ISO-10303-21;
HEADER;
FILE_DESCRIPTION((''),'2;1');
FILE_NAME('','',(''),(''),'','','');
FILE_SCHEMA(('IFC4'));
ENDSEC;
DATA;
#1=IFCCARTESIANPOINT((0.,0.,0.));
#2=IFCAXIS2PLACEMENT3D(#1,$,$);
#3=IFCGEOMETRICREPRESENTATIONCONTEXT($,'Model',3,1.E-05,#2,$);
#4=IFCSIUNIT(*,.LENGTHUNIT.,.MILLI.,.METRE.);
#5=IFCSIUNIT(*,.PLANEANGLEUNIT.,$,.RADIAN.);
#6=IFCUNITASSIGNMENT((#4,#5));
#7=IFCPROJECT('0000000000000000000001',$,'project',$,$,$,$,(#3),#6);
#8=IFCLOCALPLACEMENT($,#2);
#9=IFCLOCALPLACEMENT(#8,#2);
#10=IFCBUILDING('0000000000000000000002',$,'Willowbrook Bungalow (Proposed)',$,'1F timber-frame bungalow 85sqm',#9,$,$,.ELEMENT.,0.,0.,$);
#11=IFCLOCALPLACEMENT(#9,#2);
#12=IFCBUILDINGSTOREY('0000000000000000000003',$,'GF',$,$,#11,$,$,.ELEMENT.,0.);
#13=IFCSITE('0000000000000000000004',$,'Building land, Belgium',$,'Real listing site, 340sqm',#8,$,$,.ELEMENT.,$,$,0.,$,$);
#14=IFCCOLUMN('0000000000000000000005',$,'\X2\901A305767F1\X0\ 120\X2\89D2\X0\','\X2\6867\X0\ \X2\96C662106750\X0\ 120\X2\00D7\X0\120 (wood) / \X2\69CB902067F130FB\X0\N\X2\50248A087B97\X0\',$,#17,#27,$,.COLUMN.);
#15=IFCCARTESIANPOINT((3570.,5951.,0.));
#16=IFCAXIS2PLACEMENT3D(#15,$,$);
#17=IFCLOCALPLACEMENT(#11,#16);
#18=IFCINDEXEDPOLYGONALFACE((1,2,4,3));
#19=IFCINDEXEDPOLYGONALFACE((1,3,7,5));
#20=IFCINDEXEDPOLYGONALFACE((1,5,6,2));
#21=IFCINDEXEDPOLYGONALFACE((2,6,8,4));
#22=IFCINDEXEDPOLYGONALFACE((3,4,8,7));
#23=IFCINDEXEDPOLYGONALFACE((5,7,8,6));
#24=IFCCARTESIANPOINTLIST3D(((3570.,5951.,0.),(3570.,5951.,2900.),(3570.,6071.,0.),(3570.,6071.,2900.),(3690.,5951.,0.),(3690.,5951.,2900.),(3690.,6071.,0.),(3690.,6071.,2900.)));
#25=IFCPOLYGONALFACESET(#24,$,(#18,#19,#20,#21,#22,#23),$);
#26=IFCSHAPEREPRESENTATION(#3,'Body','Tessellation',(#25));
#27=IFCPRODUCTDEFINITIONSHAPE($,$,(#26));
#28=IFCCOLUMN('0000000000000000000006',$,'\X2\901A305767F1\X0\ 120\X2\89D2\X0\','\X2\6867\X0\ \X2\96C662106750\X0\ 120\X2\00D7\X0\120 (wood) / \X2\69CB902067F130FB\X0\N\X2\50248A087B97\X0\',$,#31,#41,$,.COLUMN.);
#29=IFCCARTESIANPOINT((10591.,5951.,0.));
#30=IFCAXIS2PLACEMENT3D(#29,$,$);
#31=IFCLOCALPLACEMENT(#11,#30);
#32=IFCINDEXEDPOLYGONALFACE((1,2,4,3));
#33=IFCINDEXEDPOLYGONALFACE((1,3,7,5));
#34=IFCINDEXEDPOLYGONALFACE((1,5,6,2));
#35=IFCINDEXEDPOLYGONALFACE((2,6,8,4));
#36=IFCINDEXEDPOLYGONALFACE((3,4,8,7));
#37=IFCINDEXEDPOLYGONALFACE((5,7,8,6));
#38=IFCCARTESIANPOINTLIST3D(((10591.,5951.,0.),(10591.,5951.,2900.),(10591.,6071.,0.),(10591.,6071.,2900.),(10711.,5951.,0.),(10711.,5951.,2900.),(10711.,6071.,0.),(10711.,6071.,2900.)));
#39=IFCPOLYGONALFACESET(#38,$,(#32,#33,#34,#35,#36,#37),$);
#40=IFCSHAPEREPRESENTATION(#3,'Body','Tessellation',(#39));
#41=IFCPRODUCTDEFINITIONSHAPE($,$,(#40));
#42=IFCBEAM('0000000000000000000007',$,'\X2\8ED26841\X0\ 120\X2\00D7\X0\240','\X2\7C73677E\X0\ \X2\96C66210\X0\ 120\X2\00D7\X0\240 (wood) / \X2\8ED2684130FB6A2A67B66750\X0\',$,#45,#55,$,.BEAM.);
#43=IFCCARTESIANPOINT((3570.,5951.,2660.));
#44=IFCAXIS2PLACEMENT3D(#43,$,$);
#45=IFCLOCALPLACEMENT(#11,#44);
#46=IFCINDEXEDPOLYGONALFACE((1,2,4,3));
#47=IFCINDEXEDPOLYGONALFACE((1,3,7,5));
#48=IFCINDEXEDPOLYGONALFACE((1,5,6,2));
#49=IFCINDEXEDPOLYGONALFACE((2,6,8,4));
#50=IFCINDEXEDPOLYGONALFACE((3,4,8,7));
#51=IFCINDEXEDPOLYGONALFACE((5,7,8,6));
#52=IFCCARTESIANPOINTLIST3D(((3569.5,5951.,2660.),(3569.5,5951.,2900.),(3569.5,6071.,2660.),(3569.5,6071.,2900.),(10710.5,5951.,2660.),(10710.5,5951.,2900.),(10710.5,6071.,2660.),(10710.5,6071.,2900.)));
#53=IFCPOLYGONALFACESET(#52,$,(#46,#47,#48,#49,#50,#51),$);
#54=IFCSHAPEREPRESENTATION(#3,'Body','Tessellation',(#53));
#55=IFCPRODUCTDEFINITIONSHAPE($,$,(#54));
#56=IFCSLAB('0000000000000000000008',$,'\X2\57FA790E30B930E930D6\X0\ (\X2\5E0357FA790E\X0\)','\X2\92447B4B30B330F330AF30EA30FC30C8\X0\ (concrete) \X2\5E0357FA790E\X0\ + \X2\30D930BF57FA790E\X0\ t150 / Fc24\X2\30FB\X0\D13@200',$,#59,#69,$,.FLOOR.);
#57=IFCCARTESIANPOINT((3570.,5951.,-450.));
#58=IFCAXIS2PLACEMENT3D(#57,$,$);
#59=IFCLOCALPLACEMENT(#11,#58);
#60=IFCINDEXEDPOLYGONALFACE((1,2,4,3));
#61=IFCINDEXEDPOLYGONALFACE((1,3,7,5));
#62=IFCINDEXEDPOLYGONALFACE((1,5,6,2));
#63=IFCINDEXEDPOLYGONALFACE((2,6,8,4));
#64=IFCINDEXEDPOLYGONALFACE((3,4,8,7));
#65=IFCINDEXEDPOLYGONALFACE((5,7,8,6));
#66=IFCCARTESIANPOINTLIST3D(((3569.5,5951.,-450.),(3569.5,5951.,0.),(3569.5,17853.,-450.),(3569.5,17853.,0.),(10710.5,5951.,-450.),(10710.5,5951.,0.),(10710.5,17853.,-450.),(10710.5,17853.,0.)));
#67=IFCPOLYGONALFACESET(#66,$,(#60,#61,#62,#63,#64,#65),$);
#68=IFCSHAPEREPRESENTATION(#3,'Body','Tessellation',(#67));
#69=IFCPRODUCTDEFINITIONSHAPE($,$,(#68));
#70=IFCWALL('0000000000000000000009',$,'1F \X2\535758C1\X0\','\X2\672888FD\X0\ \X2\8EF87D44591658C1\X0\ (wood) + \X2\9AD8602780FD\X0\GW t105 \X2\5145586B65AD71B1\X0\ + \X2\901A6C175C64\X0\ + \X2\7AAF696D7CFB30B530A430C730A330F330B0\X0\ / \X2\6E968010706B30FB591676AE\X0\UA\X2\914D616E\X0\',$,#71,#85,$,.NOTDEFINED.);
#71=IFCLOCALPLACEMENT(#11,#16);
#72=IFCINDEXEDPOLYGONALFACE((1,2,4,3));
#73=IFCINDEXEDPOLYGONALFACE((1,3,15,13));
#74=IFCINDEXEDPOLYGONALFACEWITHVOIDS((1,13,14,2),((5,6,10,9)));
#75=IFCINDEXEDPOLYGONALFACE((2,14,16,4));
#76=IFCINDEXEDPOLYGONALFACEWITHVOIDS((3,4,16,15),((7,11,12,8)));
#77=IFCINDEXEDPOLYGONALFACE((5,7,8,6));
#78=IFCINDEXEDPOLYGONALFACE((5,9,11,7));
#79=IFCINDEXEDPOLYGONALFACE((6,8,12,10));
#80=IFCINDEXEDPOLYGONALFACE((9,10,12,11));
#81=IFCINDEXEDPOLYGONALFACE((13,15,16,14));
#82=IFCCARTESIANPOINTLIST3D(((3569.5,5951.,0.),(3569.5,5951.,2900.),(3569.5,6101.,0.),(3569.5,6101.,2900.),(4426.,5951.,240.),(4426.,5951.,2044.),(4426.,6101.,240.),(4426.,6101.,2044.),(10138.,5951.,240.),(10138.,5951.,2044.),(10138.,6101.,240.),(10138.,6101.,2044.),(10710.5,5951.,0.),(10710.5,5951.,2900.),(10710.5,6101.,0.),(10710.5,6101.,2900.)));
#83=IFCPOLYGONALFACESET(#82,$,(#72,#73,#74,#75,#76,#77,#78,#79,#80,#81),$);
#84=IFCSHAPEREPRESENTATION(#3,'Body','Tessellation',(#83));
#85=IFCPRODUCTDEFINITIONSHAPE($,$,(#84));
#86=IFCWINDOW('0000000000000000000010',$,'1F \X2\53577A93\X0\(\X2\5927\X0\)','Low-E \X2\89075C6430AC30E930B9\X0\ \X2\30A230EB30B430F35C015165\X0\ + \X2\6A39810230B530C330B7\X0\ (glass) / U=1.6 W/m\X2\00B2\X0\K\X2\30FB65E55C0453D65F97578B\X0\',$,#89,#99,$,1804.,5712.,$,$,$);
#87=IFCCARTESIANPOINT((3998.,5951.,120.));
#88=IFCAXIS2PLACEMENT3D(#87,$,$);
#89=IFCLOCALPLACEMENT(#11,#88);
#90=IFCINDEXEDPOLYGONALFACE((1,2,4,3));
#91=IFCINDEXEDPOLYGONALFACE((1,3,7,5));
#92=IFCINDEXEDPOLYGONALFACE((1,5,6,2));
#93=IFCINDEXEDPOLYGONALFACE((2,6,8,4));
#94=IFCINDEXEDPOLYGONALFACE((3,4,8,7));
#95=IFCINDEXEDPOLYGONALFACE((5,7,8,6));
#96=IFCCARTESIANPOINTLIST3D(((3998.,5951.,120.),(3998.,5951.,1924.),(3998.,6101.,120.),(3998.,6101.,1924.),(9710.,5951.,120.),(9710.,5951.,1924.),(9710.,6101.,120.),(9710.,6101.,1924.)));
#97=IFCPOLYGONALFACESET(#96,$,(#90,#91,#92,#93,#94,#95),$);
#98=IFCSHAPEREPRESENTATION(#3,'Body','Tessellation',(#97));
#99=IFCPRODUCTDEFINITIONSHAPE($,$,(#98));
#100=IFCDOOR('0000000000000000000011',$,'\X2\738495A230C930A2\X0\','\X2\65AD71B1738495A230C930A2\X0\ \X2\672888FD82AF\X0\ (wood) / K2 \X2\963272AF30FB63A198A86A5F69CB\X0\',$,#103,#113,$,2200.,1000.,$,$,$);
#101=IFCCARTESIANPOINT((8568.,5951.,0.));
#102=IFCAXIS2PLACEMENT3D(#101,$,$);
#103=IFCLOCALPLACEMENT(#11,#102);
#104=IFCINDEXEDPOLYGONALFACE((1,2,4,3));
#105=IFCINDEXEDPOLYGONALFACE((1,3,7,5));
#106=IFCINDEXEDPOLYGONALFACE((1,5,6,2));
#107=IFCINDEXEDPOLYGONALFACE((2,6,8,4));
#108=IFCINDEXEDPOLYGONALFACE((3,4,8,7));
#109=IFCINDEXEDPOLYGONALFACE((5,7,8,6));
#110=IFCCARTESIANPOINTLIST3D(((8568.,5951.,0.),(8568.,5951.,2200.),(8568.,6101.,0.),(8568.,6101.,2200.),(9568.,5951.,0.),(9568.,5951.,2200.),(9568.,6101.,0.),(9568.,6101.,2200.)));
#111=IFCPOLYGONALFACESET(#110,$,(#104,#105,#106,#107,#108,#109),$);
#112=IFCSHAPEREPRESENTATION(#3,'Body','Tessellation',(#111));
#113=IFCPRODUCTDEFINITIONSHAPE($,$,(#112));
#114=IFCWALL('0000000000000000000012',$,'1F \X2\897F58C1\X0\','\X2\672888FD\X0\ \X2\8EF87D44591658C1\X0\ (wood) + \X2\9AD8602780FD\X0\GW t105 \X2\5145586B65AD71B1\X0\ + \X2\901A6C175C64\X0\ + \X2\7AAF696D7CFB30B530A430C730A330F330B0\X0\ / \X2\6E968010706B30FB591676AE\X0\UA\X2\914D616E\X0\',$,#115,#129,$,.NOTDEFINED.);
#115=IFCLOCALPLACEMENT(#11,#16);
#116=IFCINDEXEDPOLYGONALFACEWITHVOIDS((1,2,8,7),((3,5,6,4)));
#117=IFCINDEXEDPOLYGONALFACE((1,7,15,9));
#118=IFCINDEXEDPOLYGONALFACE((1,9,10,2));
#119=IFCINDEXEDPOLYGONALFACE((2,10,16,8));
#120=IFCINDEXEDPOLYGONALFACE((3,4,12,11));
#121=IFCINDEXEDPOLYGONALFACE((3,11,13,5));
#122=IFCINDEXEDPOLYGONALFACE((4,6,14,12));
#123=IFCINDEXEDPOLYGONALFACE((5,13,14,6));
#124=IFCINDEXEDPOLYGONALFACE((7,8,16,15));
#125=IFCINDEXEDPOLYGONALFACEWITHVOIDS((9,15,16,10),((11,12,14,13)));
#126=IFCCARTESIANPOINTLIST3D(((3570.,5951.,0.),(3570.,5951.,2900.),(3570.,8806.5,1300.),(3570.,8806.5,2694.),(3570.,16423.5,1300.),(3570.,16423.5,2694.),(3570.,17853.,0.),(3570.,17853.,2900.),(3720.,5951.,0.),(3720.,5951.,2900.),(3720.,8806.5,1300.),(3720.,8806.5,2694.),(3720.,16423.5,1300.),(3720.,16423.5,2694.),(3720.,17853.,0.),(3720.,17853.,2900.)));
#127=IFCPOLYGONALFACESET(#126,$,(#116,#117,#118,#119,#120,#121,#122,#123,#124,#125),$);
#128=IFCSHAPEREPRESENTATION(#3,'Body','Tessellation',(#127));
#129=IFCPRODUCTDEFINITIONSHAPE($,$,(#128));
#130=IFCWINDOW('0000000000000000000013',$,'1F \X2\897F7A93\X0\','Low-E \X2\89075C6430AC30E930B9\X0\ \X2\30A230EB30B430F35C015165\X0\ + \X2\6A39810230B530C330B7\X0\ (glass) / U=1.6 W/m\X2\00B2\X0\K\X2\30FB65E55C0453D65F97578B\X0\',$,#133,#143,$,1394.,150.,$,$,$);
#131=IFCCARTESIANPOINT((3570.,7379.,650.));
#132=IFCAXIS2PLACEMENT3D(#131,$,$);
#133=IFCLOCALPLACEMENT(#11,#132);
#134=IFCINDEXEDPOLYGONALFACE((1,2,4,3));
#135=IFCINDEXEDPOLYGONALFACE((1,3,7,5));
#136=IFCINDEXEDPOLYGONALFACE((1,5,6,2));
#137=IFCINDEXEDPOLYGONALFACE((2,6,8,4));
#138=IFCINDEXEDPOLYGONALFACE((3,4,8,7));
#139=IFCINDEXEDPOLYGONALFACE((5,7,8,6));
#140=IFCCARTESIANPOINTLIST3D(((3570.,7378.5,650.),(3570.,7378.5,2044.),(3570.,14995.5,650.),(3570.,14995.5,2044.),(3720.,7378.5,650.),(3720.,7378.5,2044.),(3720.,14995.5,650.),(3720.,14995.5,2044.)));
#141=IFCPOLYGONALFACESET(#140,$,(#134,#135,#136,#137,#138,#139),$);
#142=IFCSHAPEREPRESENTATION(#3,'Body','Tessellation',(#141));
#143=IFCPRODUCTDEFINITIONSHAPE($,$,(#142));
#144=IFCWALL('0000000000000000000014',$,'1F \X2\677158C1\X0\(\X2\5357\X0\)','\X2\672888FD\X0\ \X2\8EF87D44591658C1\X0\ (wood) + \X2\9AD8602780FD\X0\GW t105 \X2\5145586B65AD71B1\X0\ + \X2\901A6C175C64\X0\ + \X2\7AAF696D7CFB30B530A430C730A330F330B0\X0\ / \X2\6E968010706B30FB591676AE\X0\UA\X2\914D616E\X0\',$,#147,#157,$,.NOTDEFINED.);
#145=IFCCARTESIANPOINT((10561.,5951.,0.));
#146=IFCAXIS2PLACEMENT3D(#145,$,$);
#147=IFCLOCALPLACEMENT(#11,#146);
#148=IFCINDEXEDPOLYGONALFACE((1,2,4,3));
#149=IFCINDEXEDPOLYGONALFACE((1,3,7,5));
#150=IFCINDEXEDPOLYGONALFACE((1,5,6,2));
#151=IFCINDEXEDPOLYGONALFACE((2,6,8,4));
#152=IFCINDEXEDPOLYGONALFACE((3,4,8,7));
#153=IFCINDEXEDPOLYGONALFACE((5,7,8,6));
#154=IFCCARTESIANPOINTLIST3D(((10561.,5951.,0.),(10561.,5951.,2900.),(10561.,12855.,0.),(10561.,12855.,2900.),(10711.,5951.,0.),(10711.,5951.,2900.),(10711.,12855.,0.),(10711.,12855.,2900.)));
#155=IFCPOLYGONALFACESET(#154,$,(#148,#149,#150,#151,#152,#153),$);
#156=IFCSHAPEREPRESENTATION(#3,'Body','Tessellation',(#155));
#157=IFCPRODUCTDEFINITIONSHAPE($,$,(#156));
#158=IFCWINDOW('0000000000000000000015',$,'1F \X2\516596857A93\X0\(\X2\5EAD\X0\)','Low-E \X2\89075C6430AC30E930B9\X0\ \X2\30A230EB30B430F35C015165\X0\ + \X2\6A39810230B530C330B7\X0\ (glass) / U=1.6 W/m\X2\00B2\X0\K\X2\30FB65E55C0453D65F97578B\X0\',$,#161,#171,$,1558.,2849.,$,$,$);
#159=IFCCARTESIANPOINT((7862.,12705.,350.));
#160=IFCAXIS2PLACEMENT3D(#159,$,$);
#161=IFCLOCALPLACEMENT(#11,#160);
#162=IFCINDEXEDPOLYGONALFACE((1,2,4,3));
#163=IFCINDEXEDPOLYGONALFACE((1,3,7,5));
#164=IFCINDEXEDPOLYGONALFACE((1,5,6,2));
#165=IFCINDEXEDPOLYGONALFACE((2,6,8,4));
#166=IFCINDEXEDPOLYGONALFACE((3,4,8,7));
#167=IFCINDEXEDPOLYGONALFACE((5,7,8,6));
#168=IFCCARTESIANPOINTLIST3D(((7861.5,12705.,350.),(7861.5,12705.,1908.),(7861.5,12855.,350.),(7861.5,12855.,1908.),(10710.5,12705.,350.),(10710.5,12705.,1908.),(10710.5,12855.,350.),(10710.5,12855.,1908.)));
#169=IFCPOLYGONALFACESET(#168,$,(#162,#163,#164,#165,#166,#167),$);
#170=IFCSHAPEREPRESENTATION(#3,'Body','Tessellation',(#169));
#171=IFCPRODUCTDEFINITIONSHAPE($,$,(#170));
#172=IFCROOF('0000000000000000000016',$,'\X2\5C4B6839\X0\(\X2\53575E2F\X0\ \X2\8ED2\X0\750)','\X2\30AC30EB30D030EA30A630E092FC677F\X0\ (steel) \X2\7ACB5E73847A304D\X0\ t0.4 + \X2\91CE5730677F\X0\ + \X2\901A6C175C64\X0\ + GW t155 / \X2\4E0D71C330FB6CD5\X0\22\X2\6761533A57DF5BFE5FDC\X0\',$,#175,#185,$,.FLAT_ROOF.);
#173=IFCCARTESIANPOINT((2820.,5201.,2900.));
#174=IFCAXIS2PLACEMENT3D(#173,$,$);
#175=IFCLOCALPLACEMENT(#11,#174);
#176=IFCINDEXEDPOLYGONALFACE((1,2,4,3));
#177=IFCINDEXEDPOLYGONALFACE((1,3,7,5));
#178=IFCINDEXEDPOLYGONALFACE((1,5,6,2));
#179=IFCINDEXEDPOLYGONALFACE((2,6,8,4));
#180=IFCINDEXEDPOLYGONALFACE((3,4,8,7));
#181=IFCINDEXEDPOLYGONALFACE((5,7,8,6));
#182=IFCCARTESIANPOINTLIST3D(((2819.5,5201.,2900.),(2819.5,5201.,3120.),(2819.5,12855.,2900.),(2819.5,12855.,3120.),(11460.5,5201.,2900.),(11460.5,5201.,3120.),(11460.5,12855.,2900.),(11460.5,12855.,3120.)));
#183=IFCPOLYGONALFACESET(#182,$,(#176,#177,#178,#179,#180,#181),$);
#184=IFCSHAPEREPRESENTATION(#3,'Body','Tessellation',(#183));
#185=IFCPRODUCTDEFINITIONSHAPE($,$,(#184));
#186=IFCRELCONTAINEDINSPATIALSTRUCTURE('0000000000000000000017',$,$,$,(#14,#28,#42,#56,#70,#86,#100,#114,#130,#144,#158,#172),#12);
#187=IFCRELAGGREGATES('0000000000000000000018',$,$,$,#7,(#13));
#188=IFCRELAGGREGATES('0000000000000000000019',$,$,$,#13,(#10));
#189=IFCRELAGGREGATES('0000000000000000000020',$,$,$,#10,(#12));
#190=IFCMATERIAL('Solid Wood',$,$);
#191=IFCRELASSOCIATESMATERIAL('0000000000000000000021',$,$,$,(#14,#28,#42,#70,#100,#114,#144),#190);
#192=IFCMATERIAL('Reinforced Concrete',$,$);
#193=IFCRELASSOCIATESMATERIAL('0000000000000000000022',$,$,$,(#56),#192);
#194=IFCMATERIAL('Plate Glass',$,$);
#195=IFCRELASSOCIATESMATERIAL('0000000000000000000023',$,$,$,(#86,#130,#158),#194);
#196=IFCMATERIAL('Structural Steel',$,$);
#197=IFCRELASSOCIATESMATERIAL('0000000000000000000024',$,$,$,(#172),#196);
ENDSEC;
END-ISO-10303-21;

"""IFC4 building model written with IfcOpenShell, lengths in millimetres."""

from ifc_helpers import new_model, si_unit, frame, frame_2d, origin, place, context, project, spatial, rectangle, extrude, material, element, fill, save


model = new_model("IFC4")

# Units and contexts
model_context = context("Model", 3, precision=1e-05, world=origin())
ifc_project = project(units=[si_unit("LENGTHUNIT", "METRE", prefix="MILLI"), si_unit("PLANEANGLEUNIT", "RADIAN")], contexts=[model_context])

# Site, building, storey
site_placement = place(None, origin())
site = spatial("IfcSite", under=ifc_project, at=site_placement, Name="Building land, Belgium", ObjectType="Real listing site, 340sqm", CompositionType="ELEMENT", RefElevation=0.0)
building_placement = place(site_placement, origin())
building = spatial("IfcBuilding", under=site, at=building_placement, Name="Willowbrook Bungalow (Proposed)", ObjectType="1F timber-frame bungalow 85sqm", CompositionType="ELEMENT", ElevationOfRefHeight=0.0, ElevationOfTerrain=0.0)
storey_placement = place(building_placement, origin())
storey = spatial("IfcBuildingStorey", under=building, at=storey_placement, Name="GF", CompositionType="ELEMENT", Elevation=0.0)

# Columns
ifc_material_1 = material(Name="Solid Wood")
column_1_placement = place(storey_placement, frame((3570.0, 5951.0, 0.0)))
element("IfcColumn", 1, at=column_1_placement, inside=storey, material=ifc_material_1, Name="通し柱 120角", Description="桧 集成材 120×120 (wood) / 構造柱・N値計算", PredefinedType="COLUMN", context=model_context, shape_type="SweptSolid", body=[
    extrude(rectangle(XDim=120.0, YDim=120.0, at=frame_2d((60.0, 60.0))), frame((3570.0, 5951.0, 0.0)), (0.0, 0.0, 1.0), 2900.0),
])
column_2_placement = place(storey_placement, frame((10591.0, 5951.0, 0.0)))
element("IfcColumn", 2, at=column_2_placement, inside=storey, material=ifc_material_1, Name="通し柱 120角", Description="桧 集成材 120×120 (wood) / 構造柱・N値計算", PredefinedType="COLUMN", context=model_context, shape_type="SweptSolid", body=[
    extrude(rectangle(XDim=120.0, YDim=120.0, at=frame_2d((60.0, 60.0))), frame((10591.0, 5951.0, 0.0)), (0.0, 0.0, 1.0), 2900.0),
])

# Beam
beam_1_placement = place(storey_placement, frame((3570.0, 5951.0, 2660.0)))
element("IfcBeam", 3, at=beam_1_placement, inside=storey, material=ifc_material_1, Name="軒桁 120×240", Description="米松 集成 120×240 (wood) / 軒桁・横架材", PredefinedType="BEAM", context=model_context, shape_type="SweptSolid", body=[
    extrude(rectangle(XDim=7141.0, YDim=120.0, at=frame_2d((3570.0, 60.0))), frame((3570.0, 5951.0, 2660.0)), (0.0, 0.0, 1.0), 240.0),
])

# Slab
ifc_material_2 = material(Name="Reinforced Concrete")
slab_1_placement = place(storey_placement, frame((3570.0, 5951.0, -450.0)))
element("IfcSlab", 4, at=slab_1_placement, inside=storey, material=ifc_material_2, Name="基礎スラブ (布基礎)", Description="鉄筋コンクリート (concrete) 布基礎 + ベタ基礎 t150 / Fc24・D13@200", PredefinedType="FLOOR", context=model_context, shape_type="SweptSolid", body=[
    extrude(rectangle(XDim=7141.0, YDim=11902.0, at=frame_2d((3570.0, 5951.0))), frame((3570.0, 5951.0, -450.0)), (0.0, 0.0, 1.0), 450.0),
])

# Wall, openings, window, door
wall_1_placement = place(storey_placement, frame((3570.0, 5951.0, 0.0)))
wall_1 = element("IfcWall", 5, at=wall_1_placement, inside=storey, material=ifc_material_1, Name="1F 南壁", Description="木製 軸組外壁 (wood) + 高性能GW t105 充填断熱 + 通気層 + 窯業系サイディング / 準耐火・外皮UA配慮", PredefinedType="NOTDEFINED", context=model_context, shape_type="SweptSolid", body=[
    extrude(rectangle(XDim=7141.0, YDim=150.0, at=frame_2d((3570.0, 75.0))), frame((3570.0, 5951.0, 0.0)), (0.0, 0.0, 1.0), 2900.0),
])
opening_1_placement = place(storey_placement, frame((3998.0, 5951.0, 120.0)))
opening_1 = element("IfcOpeningElement", 6, at=opening_1_placement, cuts=wall_1, PredefinedType="NOTDEFINED", context=model_context, shape_type="SweptSolid", body=[
    extrude(rectangle(XDim=5712.0, YDim=150.0, at=frame_2d((2856.0, 75.0))), frame((3998.0, 5951.0, 120.0)), (0.0, 0.0, 1.0), 1804.0),
])
opening_2_placement = place(storey_placement, frame((8568.0, 5951.0, 0.0)))
opening_2 = element("IfcOpeningElement", 7, at=opening_2_placement, cuts=wall_1, PredefinedType="NOTDEFINED", context=model_context, shape_type="SweptSolid", body=[
    extrude(rectangle(XDim=1000.0, YDim=150.0, at=frame_2d((500.0, 75.0))), frame((8568.0, 5951.0, 0.0)), (0.0, 0.0, 1.0), 2200.0),
])
ifc_material_3 = material(Name="Plate Glass")
window_1_placement = place(storey_placement, frame((3998.0, 5951.0, 120.0)))
window_1 = element("IfcWindow", 8, at=window_1_placement, inside=storey, material=ifc_material_3, Name="1F 南窓(大)", Description="Low-E 複層ガラス アルゴン封入 + 樹脂サッシ (glass) / U=1.6 W/m²K・日射取得型", OverallHeight=1804.0, OverallWidth=5712.0, context=model_context, shape_type="SweptSolid", body=[
    extrude(rectangle(XDim=5712.0, YDim=150.0, at=frame_2d((2856.0, 75.0))), frame((3998.0, 5951.0, 120.0)), (0.0, 0.0, 1.0), 1804.0),
])
fill(opening_1, window_1)
door_1_placement = place(storey_placement, frame((8568.0, 5951.0, 0.0)))
door_1 = element("IfcDoor", 9, at=door_1_placement, inside=storey, material=ifc_material_1, Name="玄関ドア", Description="断熱玄関ドア 木製芯 (wood) / K2 防犯・採風機構", OverallHeight=2200.0, OverallWidth=1000.0, context=model_context, shape_type="SweptSolid", body=[
    extrude(rectangle(XDim=1000.0, YDim=150.0, at=frame_2d((500.0, 75.0))), frame((8568.0, 5951.0, 0.0)), (0.0, 0.0, 1.0), 2200.0),
])
fill(opening_2, door_1)

# Walls, openings, windows
wall_2_placement = place(storey_placement, frame((3570.0, 5951.0, 0.0)))
wall_2 = element("IfcWall", 10, at=wall_2_placement, inside=storey, material=ifc_material_1, Name="1F 西壁", Description="木製 軸組外壁 (wood) + 高性能GW t105 充填断熱 + 通気層 + 窯業系サイディング / 準耐火・外皮UA配慮", PredefinedType="NOTDEFINED", context=model_context, shape_type="SweptSolid", body=[
    extrude(rectangle(XDim=150.0, YDim=11902.0, at=frame_2d((75.0, 5951.0))), frame((3570.0, 5951.0, 0.0)), (0.0, 0.0, 1.0), 2900.0),
])
opening_3_placement = place(storey_placement, frame((3570.0, 7379.0, 650.0)))
opening_3 = element("IfcOpeningElement", 11, at=opening_3_placement, cuts=wall_2, PredefinedType="NOTDEFINED", context=model_context, shape_type="SweptSolid", body=[
    extrude(rectangle(XDim=150.0, YDim=7617.0, at=frame_2d((75.0, 3808.0))), frame((3570.0, 7379.0, 650.0)), (0.0, 0.0, 1.0), 1394.0),
])
window_2_placement = place(storey_placement, frame((3570.0, 7379.0, 650.0)))
window_2 = element("IfcWindow", 12, at=window_2_placement, inside=storey, material=ifc_material_3, Name="1F 西窓", Description="Low-E 複層ガラス アルゴン封入 + 樹脂サッシ (glass) / U=1.6 W/m²K・日射取得型", OverallHeight=1394.0, OverallWidth=150.0, context=model_context, shape_type="SweptSolid", body=[
    extrude(rectangle(XDim=150.0, YDim=7617.0, at=frame_2d((75.0, 3808.0))), frame((3570.0, 7379.0, 650.0)), (0.0, 0.0, 1.0), 1394.0),
])
fill(opening_3, window_2)
wall_3_placement = place(storey_placement, frame((10561.0, 5951.0, 0.0)))
wall_3 = element("IfcWall", 13, at=wall_3_placement, inside=storey, material=ifc_material_1, Name="1F 東壁(南)", Description="木製 軸組外壁 (wood) + 高性能GW t105 充填断熱 + 通気層 + 窯業系サイディング / 準耐火・外皮UA配慮", PredefinedType="NOTDEFINED", context=model_context, shape_type="SweptSolid", body=[
    extrude(rectangle(XDim=150.0, YDim=6904.0, at=frame_2d((75.0, 3452.0))), frame((10561.0, 5951.0, 0.0)), (0.0, 0.0, 1.0), 2900.0),
])
opening_4_placement = place(storey_placement, frame((7862.0, 12705.0, 350.0)))
opening_4 = element("IfcOpeningElement", 14, at=opening_4_placement, cuts=wall_3, PredefinedType="NOTDEFINED", context=model_context, shape_type="SweptSolid", body=[
    extrude(rectangle(XDim=2849.0, YDim=150.0, at=frame_2d((1424.0, 75.0))), frame((7862.0, 12705.0, 350.0)), (0.0, 0.0, 1.0), 1558.0),
])
window_3_placement = place(storey_placement, frame((7862.0, 12705.0, 350.0)))
window_3 = element("IfcWindow", 15, at=window_3_placement, inside=storey, material=ifc_material_3, Name="1F 入隅窓(庭)", Description="Low-E 複層ガラス アルゴン封入 + 樹脂サッシ (glass) / U=1.6 W/m²K・日射取得型", OverallHeight=1558.0, OverallWidth=2849.0, context=model_context, shape_type="SweptSolid", body=[
    extrude(rectangle(XDim=2849.0, YDim=150.0, at=frame_2d((1424.0, 75.0))), frame((7862.0, 12705.0, 350.0)), (0.0, 0.0, 1.0), 1558.0),
])
fill(opening_4, window_3)

# Roof
ifc_material_4 = material(Name="Structural Steel")
roof_placement = place(storey_placement, frame((2820.0, 5201.0, 2900.0)))
element("IfcRoof", 16, at=roof_placement, inside=storey, material=ifc_material_4, Name="屋根(南帯 軒750)", Description="ガルバリウム鋼板 (steel) 立平葺き t0.4 + 野地板 + 通気層 + GW t155 / 不燃・法22条区域対応", PredefinedType="FLAT_ROOF", context=model_context, shape_type="SweptSolid", body=[
    extrude(rectangle(XDim=8641.0, YDim=7654.0, at=frame_2d((4320.0, 3827.0))), frame((2820.0, 5201.0, 2900.0)), (0.0, 0.0, 1.0), 220.0),
])

save(model, "model.ifc")
